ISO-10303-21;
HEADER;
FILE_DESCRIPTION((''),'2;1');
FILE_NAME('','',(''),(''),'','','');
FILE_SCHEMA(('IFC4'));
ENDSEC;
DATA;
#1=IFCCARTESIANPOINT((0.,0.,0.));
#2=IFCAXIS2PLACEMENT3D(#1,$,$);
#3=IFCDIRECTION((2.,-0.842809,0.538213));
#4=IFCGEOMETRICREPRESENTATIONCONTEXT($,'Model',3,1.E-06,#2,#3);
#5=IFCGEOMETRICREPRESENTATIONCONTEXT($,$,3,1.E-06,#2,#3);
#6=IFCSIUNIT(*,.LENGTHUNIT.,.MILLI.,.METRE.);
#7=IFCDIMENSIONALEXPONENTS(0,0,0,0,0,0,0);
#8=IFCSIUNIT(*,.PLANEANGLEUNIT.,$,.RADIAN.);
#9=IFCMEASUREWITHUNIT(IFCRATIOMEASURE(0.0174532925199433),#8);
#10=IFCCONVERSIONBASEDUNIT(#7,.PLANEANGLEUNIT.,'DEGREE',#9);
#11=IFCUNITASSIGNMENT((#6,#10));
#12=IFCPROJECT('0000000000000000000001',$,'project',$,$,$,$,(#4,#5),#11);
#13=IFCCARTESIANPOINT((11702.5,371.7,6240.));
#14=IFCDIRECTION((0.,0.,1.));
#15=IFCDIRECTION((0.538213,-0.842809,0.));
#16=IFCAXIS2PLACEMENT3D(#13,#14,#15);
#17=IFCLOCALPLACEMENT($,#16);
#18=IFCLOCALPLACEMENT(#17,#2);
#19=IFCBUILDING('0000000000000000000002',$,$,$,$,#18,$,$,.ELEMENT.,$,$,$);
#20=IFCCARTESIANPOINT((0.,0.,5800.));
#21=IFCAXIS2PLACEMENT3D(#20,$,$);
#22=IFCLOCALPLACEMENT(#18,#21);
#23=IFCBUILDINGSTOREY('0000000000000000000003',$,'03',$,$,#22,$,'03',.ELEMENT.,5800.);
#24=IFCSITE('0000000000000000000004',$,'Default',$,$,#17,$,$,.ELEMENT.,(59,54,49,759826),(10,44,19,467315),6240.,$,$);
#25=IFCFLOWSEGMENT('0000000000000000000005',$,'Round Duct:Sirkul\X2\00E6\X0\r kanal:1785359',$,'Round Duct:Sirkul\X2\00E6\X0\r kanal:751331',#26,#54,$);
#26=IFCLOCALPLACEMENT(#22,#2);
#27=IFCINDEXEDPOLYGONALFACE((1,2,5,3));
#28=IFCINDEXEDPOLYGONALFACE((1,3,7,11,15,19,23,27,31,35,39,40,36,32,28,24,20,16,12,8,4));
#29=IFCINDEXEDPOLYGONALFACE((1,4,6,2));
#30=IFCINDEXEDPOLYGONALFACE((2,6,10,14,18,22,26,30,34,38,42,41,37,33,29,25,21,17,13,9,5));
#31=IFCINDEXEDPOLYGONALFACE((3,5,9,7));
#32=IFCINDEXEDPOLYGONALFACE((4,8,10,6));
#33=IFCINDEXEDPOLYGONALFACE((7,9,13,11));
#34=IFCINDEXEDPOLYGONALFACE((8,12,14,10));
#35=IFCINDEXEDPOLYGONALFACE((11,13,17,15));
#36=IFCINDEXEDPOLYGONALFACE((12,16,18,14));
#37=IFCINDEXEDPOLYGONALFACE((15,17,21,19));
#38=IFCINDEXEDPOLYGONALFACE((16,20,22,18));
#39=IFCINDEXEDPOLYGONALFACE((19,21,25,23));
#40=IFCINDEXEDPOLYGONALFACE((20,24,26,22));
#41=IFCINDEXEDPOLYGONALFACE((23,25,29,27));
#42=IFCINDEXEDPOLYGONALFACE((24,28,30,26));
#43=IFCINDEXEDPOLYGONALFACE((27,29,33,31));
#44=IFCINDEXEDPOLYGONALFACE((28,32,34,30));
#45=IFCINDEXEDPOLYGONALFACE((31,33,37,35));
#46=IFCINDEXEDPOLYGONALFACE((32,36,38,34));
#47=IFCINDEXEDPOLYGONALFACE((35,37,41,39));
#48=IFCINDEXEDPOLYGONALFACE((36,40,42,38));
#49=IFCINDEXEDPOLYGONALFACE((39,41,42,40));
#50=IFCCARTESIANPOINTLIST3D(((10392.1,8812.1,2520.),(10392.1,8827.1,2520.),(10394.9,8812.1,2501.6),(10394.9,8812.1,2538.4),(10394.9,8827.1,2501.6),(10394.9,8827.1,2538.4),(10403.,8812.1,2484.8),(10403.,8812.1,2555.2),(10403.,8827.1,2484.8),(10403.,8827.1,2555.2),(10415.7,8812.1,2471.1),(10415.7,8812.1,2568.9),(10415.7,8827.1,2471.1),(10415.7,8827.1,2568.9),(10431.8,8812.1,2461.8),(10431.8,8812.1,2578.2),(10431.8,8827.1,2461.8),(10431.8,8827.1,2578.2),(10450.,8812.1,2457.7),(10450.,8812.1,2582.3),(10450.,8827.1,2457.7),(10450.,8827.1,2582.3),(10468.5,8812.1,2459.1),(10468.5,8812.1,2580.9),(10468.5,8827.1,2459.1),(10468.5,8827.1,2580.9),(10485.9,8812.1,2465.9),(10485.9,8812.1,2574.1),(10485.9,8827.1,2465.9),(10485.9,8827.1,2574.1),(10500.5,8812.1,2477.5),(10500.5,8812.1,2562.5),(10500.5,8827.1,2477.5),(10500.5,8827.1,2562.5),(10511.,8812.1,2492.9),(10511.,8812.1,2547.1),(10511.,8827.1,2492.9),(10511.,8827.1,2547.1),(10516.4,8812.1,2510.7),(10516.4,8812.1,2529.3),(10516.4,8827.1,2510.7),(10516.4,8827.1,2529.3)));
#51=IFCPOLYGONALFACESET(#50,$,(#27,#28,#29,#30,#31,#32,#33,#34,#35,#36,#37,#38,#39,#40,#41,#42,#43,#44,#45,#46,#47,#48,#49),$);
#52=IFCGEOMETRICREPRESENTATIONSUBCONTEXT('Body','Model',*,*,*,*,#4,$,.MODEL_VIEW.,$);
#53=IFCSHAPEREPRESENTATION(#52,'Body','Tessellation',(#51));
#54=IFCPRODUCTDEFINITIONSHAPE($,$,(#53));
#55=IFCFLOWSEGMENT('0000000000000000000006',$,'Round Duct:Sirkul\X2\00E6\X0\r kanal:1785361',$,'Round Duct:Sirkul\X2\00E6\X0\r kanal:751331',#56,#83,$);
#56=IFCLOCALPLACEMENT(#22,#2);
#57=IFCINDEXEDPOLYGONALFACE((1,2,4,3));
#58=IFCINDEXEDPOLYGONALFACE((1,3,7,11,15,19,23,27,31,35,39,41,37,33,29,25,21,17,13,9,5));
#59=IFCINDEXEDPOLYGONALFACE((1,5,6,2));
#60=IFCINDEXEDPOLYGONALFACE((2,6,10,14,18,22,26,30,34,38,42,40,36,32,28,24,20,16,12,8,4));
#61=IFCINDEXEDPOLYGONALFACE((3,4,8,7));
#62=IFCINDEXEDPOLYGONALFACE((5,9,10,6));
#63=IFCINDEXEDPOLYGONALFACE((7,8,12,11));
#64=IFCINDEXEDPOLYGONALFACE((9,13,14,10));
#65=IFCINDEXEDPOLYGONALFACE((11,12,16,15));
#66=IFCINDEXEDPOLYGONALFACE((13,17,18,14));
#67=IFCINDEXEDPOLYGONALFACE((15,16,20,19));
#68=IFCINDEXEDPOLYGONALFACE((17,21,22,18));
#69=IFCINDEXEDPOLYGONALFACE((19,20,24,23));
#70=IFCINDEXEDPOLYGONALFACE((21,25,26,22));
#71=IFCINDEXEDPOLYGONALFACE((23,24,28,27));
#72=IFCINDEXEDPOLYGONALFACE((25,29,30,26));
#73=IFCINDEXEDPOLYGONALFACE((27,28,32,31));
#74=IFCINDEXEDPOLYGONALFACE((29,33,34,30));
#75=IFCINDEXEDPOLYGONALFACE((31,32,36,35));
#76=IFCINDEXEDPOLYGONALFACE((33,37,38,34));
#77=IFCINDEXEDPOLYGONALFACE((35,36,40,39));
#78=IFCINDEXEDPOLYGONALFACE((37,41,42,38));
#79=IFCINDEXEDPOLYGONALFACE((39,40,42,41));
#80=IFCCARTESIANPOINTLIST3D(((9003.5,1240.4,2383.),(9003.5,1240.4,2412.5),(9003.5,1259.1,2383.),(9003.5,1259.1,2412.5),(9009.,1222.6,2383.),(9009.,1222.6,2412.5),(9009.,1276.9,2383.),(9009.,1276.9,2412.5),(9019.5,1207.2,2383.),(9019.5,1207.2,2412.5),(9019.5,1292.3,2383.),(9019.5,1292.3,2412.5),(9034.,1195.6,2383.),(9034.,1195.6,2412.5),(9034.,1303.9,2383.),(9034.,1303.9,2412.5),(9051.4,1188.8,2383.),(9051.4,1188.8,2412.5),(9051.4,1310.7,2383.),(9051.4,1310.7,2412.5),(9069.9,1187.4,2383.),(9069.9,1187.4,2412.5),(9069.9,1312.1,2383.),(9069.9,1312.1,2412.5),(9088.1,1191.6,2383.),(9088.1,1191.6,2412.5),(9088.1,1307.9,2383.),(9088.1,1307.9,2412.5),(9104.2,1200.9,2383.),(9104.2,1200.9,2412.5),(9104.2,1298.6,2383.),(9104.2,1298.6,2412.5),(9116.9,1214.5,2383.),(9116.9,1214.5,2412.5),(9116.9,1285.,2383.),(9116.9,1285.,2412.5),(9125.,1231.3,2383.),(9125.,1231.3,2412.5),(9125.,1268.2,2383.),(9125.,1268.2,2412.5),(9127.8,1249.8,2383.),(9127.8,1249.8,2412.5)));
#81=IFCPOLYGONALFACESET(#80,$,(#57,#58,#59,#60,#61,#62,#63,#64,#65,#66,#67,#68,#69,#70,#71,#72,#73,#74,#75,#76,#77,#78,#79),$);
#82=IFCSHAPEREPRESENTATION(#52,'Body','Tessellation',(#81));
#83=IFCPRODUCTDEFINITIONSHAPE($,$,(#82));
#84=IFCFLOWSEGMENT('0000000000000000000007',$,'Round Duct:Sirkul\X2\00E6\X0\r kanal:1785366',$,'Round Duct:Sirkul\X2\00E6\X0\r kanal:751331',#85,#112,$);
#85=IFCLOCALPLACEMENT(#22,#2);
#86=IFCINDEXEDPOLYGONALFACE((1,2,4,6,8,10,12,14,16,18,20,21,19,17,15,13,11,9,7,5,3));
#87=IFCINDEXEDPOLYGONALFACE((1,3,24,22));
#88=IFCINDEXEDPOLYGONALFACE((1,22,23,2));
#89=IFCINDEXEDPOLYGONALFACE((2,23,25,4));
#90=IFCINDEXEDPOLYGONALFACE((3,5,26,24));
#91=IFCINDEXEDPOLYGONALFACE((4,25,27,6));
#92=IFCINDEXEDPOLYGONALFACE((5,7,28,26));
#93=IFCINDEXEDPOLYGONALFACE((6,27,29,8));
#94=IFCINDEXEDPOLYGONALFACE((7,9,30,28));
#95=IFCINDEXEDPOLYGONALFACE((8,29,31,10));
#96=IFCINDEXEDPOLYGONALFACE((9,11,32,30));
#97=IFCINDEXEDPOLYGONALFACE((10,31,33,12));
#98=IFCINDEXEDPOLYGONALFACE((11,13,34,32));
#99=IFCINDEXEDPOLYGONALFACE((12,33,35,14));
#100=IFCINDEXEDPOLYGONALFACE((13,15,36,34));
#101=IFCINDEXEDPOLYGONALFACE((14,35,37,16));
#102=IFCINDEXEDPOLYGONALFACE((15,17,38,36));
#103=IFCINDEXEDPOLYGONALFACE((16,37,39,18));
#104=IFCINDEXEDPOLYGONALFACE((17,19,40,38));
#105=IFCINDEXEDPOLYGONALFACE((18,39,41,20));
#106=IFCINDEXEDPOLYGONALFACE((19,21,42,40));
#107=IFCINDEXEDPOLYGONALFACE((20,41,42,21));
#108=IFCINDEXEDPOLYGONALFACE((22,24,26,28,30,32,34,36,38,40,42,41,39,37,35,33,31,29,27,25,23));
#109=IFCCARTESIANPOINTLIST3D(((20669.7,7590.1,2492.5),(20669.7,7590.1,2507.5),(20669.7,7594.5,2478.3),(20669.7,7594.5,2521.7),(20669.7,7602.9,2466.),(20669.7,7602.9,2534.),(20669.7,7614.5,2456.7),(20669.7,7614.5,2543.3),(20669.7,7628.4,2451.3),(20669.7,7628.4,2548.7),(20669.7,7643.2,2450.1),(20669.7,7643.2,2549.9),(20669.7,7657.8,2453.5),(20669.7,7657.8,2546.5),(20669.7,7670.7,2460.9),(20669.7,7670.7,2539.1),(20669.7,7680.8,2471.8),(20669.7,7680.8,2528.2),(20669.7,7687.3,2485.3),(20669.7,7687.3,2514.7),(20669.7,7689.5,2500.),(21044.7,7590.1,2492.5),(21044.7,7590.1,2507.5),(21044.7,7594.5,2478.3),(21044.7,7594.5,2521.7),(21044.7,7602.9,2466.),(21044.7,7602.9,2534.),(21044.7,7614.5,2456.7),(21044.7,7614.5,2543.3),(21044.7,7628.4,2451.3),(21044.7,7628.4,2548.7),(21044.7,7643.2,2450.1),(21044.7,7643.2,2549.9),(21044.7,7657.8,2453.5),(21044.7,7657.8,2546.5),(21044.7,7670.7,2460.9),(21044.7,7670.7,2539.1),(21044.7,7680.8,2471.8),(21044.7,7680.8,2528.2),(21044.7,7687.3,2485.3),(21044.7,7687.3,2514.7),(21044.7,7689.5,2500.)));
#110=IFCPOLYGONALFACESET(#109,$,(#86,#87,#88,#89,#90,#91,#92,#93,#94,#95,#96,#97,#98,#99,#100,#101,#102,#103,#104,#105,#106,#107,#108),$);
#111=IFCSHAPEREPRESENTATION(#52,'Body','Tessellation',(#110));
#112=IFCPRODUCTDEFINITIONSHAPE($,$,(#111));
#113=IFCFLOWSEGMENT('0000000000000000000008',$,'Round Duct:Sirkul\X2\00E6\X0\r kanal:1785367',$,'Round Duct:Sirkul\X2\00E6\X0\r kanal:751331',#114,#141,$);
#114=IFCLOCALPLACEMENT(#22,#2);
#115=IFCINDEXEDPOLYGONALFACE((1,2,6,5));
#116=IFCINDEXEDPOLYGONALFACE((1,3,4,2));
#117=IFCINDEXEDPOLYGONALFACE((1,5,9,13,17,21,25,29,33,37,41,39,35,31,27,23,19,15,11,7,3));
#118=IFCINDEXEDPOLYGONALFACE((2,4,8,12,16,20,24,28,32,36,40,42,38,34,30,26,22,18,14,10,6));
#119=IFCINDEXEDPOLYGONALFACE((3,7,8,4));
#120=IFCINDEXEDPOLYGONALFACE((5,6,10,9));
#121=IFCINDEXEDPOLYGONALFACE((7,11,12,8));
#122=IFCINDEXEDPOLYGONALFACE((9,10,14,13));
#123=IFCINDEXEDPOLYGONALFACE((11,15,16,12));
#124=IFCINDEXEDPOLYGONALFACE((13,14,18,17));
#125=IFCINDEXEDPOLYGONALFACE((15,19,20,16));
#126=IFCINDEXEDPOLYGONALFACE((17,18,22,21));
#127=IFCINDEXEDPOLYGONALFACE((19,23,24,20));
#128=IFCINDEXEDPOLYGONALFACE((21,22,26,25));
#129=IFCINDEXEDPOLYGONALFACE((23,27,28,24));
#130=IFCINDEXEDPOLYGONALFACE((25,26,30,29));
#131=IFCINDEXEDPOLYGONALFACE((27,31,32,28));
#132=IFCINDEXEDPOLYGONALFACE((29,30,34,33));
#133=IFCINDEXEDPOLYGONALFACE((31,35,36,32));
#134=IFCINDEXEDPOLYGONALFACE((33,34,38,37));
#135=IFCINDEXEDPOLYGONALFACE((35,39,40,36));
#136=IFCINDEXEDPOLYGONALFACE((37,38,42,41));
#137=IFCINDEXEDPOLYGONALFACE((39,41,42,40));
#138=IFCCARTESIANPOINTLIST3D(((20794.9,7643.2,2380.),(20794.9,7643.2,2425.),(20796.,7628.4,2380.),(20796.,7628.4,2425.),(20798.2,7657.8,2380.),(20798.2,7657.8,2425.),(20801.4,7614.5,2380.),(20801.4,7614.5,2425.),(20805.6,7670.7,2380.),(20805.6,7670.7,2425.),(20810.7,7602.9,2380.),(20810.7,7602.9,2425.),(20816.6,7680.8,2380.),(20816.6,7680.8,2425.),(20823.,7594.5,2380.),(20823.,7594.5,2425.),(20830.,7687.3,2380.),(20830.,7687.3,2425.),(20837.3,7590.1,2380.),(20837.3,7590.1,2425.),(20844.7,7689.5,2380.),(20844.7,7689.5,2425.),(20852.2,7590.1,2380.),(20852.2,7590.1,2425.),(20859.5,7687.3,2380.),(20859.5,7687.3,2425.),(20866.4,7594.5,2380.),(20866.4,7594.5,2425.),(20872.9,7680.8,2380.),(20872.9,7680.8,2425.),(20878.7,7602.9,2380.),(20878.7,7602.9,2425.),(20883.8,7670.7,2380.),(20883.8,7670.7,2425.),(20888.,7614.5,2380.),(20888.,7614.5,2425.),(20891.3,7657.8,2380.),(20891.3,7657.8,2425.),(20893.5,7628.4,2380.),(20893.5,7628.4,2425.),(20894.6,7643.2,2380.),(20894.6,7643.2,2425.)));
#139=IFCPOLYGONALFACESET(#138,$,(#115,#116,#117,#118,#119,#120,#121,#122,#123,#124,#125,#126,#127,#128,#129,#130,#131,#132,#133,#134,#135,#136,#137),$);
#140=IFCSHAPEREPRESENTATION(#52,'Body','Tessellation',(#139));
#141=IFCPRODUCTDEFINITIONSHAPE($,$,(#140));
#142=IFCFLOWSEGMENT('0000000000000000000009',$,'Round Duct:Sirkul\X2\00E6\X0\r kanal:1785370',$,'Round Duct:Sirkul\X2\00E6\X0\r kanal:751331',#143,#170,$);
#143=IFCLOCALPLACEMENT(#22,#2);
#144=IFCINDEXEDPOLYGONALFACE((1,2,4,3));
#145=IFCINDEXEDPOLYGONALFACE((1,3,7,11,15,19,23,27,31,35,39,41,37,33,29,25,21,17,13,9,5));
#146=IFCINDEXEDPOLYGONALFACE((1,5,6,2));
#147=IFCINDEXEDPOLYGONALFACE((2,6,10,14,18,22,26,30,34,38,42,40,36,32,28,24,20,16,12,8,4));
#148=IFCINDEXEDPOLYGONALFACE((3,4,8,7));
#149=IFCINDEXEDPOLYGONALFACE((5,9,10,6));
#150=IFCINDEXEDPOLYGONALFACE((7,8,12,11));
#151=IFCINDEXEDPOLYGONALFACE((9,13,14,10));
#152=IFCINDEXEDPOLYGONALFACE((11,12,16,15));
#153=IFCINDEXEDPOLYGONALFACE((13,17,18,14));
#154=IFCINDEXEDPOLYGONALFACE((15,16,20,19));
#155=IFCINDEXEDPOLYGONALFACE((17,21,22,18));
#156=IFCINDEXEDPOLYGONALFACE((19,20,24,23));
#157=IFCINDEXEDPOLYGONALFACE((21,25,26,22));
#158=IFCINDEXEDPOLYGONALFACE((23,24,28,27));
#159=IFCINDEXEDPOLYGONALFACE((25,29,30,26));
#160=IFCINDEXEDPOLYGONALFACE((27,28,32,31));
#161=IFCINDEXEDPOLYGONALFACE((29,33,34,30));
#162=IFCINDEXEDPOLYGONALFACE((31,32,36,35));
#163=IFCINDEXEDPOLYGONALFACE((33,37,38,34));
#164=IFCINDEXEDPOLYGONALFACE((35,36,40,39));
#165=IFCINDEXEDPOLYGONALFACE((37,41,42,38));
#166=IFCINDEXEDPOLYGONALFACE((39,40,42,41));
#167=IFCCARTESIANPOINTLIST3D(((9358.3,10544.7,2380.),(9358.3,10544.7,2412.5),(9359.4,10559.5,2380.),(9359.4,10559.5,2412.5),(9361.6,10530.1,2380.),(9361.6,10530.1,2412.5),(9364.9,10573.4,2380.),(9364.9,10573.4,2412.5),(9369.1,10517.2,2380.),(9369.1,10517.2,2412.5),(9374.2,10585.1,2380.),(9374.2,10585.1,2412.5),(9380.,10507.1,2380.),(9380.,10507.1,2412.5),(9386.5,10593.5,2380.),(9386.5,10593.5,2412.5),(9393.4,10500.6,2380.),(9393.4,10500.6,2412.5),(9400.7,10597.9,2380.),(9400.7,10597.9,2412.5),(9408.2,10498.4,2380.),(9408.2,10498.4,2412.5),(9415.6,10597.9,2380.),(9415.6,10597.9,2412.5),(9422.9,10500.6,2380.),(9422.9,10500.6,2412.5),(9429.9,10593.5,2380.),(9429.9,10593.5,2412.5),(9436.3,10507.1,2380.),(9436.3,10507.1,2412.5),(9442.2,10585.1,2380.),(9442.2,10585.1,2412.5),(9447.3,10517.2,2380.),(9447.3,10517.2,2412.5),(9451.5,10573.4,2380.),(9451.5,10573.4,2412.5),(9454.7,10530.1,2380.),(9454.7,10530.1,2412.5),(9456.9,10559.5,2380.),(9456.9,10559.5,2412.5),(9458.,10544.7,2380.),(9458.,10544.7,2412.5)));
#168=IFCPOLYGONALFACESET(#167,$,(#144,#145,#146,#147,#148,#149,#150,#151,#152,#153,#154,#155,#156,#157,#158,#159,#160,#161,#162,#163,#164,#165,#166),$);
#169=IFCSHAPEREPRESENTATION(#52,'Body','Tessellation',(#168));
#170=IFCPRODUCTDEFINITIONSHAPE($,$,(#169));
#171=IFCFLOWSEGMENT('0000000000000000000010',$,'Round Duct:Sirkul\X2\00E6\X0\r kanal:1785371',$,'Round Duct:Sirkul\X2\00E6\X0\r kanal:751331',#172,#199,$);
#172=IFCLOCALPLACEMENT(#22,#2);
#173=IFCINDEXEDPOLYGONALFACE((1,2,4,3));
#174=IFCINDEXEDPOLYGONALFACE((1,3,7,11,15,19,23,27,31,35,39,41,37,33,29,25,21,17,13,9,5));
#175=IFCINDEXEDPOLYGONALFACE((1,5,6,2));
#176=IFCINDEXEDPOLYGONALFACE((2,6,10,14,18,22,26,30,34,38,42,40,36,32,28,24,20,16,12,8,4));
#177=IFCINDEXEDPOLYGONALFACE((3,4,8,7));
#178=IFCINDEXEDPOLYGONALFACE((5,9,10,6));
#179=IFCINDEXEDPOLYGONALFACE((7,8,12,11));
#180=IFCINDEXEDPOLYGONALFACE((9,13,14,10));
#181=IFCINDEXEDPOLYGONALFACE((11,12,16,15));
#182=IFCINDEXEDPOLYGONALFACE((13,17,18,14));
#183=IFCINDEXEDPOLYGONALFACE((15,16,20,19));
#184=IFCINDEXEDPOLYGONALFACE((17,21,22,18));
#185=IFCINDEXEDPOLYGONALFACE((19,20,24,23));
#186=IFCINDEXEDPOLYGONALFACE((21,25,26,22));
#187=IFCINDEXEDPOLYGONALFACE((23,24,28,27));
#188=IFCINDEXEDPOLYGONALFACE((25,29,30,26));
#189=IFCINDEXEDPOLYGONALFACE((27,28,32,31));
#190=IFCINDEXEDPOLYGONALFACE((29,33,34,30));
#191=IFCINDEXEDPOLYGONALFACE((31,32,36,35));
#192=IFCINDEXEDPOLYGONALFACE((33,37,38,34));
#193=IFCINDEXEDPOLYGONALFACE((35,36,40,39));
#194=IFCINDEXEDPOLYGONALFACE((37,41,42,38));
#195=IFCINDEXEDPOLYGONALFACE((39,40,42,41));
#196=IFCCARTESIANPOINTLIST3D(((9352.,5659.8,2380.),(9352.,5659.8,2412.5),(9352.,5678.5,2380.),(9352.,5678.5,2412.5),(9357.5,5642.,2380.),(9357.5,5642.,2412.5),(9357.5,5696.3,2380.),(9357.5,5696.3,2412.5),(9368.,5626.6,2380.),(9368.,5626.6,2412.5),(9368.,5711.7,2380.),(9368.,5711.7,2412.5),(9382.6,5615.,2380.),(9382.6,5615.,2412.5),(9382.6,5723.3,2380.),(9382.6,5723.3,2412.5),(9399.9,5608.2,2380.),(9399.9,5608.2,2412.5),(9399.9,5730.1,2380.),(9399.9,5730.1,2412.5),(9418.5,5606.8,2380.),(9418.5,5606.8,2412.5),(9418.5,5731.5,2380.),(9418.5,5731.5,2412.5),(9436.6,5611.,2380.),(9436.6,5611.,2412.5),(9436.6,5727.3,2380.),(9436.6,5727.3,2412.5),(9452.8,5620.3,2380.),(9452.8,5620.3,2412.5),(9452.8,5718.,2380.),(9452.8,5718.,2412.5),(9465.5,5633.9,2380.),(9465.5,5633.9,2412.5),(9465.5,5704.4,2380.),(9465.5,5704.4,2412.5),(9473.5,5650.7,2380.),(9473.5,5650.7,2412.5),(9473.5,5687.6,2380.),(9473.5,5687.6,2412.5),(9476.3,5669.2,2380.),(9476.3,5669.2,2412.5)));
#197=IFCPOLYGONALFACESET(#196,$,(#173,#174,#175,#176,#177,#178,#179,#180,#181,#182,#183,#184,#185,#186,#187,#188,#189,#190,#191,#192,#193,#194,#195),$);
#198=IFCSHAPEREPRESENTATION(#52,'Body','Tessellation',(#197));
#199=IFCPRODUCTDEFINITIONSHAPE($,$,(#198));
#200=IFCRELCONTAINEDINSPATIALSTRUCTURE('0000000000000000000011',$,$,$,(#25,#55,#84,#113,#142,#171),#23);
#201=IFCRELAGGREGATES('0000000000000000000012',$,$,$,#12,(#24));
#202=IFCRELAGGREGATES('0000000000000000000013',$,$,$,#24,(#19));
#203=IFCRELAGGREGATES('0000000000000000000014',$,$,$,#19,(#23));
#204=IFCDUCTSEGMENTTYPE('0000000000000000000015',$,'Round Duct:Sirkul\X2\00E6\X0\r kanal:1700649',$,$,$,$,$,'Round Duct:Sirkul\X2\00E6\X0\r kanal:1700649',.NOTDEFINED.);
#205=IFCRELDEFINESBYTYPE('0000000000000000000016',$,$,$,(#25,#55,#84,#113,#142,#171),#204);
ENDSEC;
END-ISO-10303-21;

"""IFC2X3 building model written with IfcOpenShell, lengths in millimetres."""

from ifc_helpers import new_model, entity, si_unit, converted_unit, direction, frame, frame_2d, origin, place, context, subcontext, project, spatial, circle, extrude, type_object, element, save


model = new_model("IFC2X3")

# Units and contexts
model_context = context("Model", 3, precision=1e-06, world=origin(), true_north=direction((2.0, -0.842809, 0.538213)))
context_of_model = context(None, 3, precision=1e-06, world=origin(), true_north=direction((2.0, -0.842809, 0.538213)))
body_context = subcontext(model_context, "Body", "Model", "MODEL_VIEW")
ifc_project = project(units=[si_unit("LENGTHUNIT", "METRE", prefix="MILLI"), converted_unit("PLANEANGLEUNIT", "DEGREE", entity("IfcRatioMeasure", 0.0174532925199433), si_unit("PLANEANGLEUNIT", "RADIAN"), dimensions=[0, 0, 0, 0, 0, 0, 0])], contexts=[model_context, context_of_model])

# Site, building, storey
site_placement = place(None, frame((11702.5, 371.7, 6240.0), z_axis=(0.0, 0.0, 1.0), x_axis=(0.538213, -0.842809, 0.0)))
site = spatial("IfcSite", under=ifc_project, at=site_placement, Name="Default", CompositionType="ELEMENT", RefLatitude=(59, 54, 49, 759826), RefLongitude=(10, 44, 19, 467315), RefElevation=6240.0)
building_placement = place(site_placement, origin())
building = spatial("IfcBuilding", under=site, at=building_placement, CompositionType="ELEMENT")
storey_placement = place(building_placement, frame((0.0, 0.0, 5800.0)))
storey = spatial("IfcBuildingStorey", under=building, at=storey_placement, Name="03", LongName="03", CompositionType="ELEMENT", Elevation=5800.0)

# Flow segments
duct_segment_type = type_object("IfcDuctSegmentType", Name="Round Duct:Sirkulær kanal:1700649", ElementType="Round Duct:Sirkulær kanal:1700649", PredefinedType="NOTDEFINED")
flow_segment_1_placement = place(storey_placement, origin())
element("IfcFlowSegment", 1, at=flow_segment_1_placement, inside=storey, type_object=duct_segment_type, Name="Round Duct:Sirkulær kanal:1785359", ObjectType="Round Duct:Sirkulær kanal:751331", context=body_context, shape_type="SweptSolid", body=[
    extrude(circle(Radius=62.5, at=frame_2d((0.0, 0.0), x_axis=(1.0, 0.0))), frame((10454.6, 8812.1, 2520.0), z_axis=(0.0, 1.0, 0.0), x_axis=(-1.0, 0.0, 0.0)), (0.0, 0.0, 1.0), 15.0),
])
flow_segment_2_placement = place(storey_placement, origin())
element("IfcFlowSegment", 2, at=flow_segment_2_placement, inside=storey, type_object=duct_segment_type, Name="Round Duct:Sirkulær kanal:1785361", ObjectType="Round Duct:Sirkulær kanal:751331", context=body_context, shape_type="SweptSolid", body=[
    extrude(circle(Radius=62.5, at=frame_2d((0.0, 0.0), x_axis=(1.0, 0.0))), frame((9065.3, 1249.8, 2383.0)), (0.0, 0.0, 1.0), 29.5),
])
flow_segment_3_placement = place(storey_placement, origin())
element("IfcFlowSegment", 3, at=flow_segment_3_placement, inside=storey, type_object=duct_segment_type, Name="Round Duct:Sirkulær kanal:1785366", ObjectType="Round Duct:Sirkulær kanal:751331", context=body_context, shape_type="SweptSolid", body=[
    extrude(circle(Radius=50.0, at=frame_2d((0.0, 0.0), x_axis=(1.0, 0.0))), frame((20669.7, 7639.5, 2500.0), z_axis=(1.0, 0.0, 0.0), x_axis=(0.0, 1.0, 0.0)), (0.0, 0.0, 1.0), 375.0),
])
flow_segment_4_placement = place(storey_placement, origin())
element("IfcFlowSegment", 4, at=flow_segment_4_placement, inside=storey, type_object=duct_segment_type, Name="Round Duct:Sirkulær kanal:1785367", ObjectType="Round Duct:Sirkulær kanal:751331", context=body_context, shape_type="SweptSolid", body=[
    extrude(circle(Radius=50.0, at=frame_2d((0.0, 0.0), x_axis=(1.0, 0.0))), frame((20844.7, 7639.5, 2380.0), z_axis=(0.0, 0.0, 1.0), x_axis=(0.0, 1.0, 0.0)), (0.0, 0.0, 1.0), 45.0),
])
flow_segment_5_placement = place(storey_placement, origin())
element("IfcFlowSegment", 5, at=flow_segment_5_placement, inside=storey, type_object=duct_segment_type, Name="Round Duct:Sirkulær kanal:1785370", ObjectType="Round Duct:Sirkulær kanal:751331", context=body_context, shape_type="SweptSolid", body=[
    extrude(circle(Radius=50.0, at=frame_2d((0.0, 0.0), x_axis=(1.0, 0.0))), frame((9408.2, 10548.4, 2380.0), z_axis=(0.0, 0.0, 1.0), x_axis=(0.0, -1.0, 0.0)), (0.0, 0.0, 1.0), 32.5),
])
flow_segment_6_placement = place(storey_placement, origin())
element("IfcFlowSegment", 6, at=flow_segment_6_placement, inside=storey, type_object=duct_segment_type, Name="Round Duct:Sirkulær kanal:1785371", ObjectType="Round Duct:Sirkulær kanal:751331", context=body_context, shape_type="SweptSolid", body=[
    extrude(circle(Radius=62.5, at=frame_2d((0.0, 0.0), x_axis=(1.0, 0.0))), frame((9413.8, 5669.2, 2380.0)), (0.0, 0.0, 1.0), 32.5),
])

save(model, "model.ifc")
